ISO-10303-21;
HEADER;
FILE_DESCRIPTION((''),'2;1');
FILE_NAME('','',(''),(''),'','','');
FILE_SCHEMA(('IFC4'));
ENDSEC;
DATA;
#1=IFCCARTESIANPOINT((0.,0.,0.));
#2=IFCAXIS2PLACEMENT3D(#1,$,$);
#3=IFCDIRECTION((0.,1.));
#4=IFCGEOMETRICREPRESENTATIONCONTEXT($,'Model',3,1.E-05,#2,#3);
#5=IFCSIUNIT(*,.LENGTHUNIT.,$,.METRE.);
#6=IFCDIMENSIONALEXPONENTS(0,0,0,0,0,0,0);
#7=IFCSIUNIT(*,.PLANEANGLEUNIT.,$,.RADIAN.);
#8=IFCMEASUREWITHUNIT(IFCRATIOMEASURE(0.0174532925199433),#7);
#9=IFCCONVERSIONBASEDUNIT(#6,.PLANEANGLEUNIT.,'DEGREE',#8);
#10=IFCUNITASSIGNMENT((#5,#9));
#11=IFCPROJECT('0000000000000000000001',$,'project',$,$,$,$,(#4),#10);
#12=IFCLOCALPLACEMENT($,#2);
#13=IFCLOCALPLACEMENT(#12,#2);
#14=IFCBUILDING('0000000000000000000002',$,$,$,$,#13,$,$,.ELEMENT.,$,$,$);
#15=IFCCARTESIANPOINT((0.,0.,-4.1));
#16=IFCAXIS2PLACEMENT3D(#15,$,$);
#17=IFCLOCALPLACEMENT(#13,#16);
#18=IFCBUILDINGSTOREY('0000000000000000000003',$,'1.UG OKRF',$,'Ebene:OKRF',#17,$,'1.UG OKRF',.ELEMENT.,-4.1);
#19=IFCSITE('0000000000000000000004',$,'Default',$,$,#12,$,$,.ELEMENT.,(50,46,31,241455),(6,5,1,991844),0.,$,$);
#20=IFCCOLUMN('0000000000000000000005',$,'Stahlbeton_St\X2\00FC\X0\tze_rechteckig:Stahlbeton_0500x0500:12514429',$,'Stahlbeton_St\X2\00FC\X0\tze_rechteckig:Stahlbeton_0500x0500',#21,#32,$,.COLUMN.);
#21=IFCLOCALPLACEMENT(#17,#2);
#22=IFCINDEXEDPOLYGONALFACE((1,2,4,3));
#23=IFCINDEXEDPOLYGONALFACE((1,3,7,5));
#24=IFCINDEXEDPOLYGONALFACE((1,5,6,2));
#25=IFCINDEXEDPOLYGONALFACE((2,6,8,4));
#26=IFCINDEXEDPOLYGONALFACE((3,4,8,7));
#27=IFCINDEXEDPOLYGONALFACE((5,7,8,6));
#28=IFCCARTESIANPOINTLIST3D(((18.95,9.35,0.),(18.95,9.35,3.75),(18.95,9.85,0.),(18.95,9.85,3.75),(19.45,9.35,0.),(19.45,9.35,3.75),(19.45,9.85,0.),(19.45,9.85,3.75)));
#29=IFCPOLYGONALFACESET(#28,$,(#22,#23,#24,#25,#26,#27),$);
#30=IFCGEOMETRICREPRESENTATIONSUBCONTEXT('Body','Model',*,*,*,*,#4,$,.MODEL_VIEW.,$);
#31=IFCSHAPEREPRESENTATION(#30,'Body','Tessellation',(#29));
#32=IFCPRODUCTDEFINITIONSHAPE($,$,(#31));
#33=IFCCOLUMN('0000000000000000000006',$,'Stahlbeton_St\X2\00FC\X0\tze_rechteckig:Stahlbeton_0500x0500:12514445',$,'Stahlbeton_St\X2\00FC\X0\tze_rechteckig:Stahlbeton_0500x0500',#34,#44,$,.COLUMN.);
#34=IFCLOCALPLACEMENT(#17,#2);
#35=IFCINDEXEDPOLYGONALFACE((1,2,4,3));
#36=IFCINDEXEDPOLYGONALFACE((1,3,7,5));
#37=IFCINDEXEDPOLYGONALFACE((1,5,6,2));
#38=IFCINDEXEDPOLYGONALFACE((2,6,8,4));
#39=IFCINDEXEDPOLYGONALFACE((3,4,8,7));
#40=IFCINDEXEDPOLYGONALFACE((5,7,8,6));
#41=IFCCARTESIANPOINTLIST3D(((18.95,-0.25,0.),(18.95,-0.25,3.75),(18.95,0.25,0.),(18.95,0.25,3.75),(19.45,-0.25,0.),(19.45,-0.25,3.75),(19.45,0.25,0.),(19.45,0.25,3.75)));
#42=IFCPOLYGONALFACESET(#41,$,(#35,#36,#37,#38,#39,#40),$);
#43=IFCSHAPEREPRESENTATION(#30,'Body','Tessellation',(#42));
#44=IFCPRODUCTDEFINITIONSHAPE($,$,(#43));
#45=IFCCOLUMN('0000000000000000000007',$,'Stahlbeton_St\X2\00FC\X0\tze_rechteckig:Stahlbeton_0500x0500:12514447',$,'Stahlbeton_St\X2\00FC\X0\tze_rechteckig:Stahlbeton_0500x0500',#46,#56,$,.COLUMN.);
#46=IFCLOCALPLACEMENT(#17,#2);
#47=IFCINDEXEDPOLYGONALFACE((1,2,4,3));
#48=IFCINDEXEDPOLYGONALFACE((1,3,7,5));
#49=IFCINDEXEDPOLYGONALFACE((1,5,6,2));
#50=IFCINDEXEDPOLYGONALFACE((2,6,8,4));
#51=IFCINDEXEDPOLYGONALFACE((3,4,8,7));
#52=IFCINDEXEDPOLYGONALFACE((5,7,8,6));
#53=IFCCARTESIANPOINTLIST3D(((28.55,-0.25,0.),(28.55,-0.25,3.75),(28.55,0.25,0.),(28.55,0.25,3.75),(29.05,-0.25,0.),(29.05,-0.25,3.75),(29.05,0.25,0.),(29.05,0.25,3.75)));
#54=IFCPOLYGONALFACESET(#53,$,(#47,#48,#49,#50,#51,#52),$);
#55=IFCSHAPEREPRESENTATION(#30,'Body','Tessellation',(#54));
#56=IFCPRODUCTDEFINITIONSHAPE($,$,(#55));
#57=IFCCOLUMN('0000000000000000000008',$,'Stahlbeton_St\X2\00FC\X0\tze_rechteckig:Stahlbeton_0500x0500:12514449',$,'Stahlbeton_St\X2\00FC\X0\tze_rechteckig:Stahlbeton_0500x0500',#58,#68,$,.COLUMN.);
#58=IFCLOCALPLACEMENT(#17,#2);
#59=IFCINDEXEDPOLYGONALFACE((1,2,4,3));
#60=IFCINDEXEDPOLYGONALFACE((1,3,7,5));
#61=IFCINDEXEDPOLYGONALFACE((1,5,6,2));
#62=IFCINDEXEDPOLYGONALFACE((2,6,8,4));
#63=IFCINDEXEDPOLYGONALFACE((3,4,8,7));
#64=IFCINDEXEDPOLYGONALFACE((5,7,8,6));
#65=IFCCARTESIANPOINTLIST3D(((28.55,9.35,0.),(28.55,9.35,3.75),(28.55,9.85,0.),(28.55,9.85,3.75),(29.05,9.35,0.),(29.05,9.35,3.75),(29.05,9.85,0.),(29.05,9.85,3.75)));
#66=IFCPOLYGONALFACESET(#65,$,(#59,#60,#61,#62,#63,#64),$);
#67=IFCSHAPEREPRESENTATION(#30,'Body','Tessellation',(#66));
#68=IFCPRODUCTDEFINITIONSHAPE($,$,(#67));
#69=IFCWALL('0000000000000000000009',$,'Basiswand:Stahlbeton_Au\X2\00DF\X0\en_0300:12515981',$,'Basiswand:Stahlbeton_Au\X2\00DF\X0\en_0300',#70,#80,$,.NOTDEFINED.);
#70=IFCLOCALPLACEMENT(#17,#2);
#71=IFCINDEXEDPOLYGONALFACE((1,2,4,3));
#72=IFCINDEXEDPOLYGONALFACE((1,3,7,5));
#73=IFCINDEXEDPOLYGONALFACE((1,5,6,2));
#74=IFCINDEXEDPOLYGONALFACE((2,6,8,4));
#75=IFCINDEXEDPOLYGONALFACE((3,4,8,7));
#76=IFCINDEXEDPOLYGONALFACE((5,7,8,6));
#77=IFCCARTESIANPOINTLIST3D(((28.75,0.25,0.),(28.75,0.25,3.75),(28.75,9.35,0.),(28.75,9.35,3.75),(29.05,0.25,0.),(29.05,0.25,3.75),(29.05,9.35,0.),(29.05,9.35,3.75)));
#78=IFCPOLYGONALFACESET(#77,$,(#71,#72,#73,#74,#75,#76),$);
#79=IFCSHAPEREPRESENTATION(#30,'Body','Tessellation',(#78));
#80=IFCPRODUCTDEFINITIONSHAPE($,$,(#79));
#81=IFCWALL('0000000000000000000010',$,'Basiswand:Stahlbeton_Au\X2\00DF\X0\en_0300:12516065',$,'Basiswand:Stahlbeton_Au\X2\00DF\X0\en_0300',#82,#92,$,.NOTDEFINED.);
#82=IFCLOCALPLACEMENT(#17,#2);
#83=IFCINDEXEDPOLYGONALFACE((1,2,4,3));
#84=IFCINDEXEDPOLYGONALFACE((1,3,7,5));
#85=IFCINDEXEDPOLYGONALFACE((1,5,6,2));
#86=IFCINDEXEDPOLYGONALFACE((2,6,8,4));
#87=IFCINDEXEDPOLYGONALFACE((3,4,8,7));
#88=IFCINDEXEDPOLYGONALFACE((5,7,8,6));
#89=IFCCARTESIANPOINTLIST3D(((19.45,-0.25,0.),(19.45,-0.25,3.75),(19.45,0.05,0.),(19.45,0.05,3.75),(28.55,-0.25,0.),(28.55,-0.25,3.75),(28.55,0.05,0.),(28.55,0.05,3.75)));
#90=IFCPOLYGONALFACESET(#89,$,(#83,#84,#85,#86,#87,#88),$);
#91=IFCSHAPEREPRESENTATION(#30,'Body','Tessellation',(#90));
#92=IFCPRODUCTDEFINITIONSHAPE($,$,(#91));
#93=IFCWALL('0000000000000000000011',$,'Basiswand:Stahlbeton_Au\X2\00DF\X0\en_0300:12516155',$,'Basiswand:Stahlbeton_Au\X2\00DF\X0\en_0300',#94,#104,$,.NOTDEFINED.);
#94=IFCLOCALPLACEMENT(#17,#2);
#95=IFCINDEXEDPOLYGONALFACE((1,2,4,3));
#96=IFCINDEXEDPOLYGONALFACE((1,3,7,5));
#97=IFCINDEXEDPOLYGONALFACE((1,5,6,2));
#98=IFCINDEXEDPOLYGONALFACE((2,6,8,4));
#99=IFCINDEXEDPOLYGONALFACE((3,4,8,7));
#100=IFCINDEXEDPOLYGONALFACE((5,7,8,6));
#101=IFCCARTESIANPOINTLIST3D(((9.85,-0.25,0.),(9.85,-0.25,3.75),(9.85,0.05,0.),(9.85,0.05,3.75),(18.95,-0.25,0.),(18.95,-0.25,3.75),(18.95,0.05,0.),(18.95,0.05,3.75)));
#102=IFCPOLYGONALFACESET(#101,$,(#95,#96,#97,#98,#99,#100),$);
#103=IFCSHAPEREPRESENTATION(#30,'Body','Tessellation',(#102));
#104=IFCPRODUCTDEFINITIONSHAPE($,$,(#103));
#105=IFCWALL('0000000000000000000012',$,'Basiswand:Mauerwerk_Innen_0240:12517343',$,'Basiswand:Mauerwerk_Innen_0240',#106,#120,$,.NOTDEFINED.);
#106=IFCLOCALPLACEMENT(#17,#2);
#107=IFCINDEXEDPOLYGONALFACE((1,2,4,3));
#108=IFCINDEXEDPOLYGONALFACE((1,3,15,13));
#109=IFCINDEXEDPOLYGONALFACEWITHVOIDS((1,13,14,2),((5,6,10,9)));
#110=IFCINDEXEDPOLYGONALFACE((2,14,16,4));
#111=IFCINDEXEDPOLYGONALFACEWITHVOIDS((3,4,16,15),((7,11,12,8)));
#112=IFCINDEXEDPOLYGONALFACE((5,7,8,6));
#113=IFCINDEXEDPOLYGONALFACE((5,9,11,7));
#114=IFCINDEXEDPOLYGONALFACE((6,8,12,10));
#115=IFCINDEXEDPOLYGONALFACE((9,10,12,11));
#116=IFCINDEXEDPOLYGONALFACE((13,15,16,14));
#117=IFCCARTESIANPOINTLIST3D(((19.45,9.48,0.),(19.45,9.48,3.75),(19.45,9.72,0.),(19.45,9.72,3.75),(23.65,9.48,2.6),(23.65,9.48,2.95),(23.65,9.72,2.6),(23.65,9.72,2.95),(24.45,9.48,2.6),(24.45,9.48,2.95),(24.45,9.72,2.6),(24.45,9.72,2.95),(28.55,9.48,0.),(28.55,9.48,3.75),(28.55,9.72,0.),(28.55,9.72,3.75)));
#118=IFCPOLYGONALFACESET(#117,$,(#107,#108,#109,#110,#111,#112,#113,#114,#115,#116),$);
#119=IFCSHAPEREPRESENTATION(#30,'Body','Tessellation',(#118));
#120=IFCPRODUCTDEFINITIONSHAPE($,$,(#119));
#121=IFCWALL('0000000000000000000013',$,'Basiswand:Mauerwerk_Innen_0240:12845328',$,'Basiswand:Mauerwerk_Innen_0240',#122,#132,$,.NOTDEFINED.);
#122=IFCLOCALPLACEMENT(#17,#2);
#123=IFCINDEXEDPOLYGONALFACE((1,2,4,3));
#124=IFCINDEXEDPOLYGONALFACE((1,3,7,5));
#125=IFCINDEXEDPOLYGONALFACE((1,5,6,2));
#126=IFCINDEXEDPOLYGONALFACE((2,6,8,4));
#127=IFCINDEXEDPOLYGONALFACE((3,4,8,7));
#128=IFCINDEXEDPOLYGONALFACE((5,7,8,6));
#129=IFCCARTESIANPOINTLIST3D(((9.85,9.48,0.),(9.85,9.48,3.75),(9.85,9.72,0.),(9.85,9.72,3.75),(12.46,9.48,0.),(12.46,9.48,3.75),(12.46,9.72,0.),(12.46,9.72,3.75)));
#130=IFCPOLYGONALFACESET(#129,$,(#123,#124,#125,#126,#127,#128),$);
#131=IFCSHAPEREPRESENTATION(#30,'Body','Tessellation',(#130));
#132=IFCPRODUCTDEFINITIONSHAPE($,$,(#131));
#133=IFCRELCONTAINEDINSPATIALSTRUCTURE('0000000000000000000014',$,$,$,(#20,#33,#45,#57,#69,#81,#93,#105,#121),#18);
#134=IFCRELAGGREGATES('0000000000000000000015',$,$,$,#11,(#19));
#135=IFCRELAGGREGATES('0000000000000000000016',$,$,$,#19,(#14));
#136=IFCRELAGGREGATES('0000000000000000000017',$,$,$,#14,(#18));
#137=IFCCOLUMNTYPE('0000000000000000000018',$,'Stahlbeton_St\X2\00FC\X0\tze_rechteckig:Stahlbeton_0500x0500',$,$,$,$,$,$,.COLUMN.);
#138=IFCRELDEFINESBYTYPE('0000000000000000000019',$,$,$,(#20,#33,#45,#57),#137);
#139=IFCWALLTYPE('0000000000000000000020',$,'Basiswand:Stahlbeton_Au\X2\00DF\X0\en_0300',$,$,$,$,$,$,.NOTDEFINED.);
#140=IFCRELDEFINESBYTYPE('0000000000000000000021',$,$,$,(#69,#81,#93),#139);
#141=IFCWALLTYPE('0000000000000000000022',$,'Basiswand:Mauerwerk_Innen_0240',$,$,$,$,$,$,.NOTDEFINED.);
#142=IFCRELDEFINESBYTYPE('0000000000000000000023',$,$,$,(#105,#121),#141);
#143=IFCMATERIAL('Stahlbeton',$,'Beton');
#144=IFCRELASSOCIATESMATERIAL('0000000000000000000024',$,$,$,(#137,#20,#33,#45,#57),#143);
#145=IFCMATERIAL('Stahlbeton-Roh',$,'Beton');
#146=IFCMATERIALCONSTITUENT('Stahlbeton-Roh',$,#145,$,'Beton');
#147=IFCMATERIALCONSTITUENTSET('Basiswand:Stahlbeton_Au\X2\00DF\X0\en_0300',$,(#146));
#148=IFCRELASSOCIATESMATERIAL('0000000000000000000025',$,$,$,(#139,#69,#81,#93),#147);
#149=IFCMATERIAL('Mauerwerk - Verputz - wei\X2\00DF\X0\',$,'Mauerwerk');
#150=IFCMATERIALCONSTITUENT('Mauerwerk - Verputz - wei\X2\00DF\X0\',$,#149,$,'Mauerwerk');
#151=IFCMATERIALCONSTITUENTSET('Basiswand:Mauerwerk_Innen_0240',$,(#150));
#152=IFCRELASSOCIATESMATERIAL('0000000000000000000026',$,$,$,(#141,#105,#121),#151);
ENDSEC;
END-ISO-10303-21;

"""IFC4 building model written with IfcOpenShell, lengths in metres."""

from ifc_helpers import new_model, entity, si_unit, converted_unit, direction, frame, origin, place, context, subcontext, project, spatial, polyline, indexed_curve, outline, extrude, source, transform, mapped, material, constituent, constituent_set, type_object, type_shapes, element, save


model = new_model("IFC4")

# Units and contexts
model_context = context("Model", 3, precision=1e-05, world=origin(), true_north=direction((0.0, 1.0)))
body_context = subcontext(model_context, "Body", "Model", "MODEL_VIEW")
ifc_project = project(units=[si_unit("LENGTHUNIT", "METRE"), converted_unit("PLANEANGLEUNIT", "DEGREE", entity("IfcRatioMeasure", 0.0174532925199433), si_unit("PLANEANGLEUNIT", "RADIAN"), dimensions=[0, 0, 0, 0, 0, 0, 0])], contexts=[model_context])

# Site, building, storey
site_placement = place(None, origin())
site = spatial("IfcSite", under=ifc_project, at=site_placement, Name="Default", CompositionType="ELEMENT", RefLatitude=(50, 46, 31, 241455), RefLongitude=(6, 5, 1, 991844), RefElevation=0.0)
building_placement = place(site_placement, origin())
building = spatial("IfcBuilding", under=site, at=building_placement, CompositionType="ELEMENT")
storey_placement = place(building_placement, frame((0.0, 0.0, -4.1)))
storey = spatial("IfcBuildingStorey", under=building, at=storey_placement, Name="1.UG OKRF", ObjectType="Ebene:OKRF", LongName="1.UG OKRF", CompositionType="ELEMENT", Elevation=-4.1)

# Columns
ifc_material_1 = material(Name="Stahlbeton", Category="Beton")
column_type = type_object("IfcColumnType", Name="Stahlbeton_Stütze_rechteckig:Stahlbeton_0500x0500", PredefinedType="COLUMN", material=ifc_material_1)
shared_shape = source(origin(), body_context, "Body", "SweptSolid", [
    extrude(outline(indexed_curve([(-0.25, -0.25), (0.25, -0.25), (0.25, 0.25), (-0.25, 0.25), (-0.25, -0.25)], self_intersect=False)), frame((0.0, 0.0, -4.1), z_axis=(0.0, 0.0, 1.0), x_axis=(0.0, -1.0, 0.0)), (0.0, 0.0, 1.0), 3.75),
])
type_shapes(column_type, [shared_shape])
for number, where, name in (
    (1, (19.2, 9.6, 4.1), "Stahlbeton_Stütze_rechteckig:Stahlbeton_0500x0500:12514429"),
    (2, (19.2, 0.0, 4.1), "Stahlbeton_Stütze_rechteckig:Stahlbeton_0500x0500:12514445"),
    (3, (28.8, 0.0, 4.1), "Stahlbeton_Stütze_rechteckig:Stahlbeton_0500x0500:12514447"),
    (4, (28.8, 9.6, 4.1), "Stahlbeton_Stütze_rechteckig:Stahlbeton_0500x0500:12514449"),
):
    element("IfcColumn", number, at=place(storey_placement, frame(where)), inside=storey, type_object=column_type, material=ifc_material_1, Name=name, ObjectType="Stahlbeton_Stütze_rechteckig:Stahlbeton_0500x0500", PredefinedType="COLUMN", context=body_context, shape_type="MappedRepresentation", body=[
        mapped(shared_shape, transform((0.0, 0.0, 0.0), scale=1.0)),
    ])

# Walls
ifc_material_2 = material(Name="Stahlbeton-Roh", Category="Beton")
ifc_constituent_1 = constituent(ifc_material_2, Name="Stahlbeton-Roh", Category="Beton")
ifc_constituent_set_1 = constituent_set(constituents=[ifc_constituent_1], Name="Basiswand:Stahlbeton_Außen_0300")
wall_type_1 = type_object("IfcWallType", Name="Basiswand:Stahlbeton_Außen_0300", PredefinedType="NOTDEFINED", material=ifc_constituent_set_1)
wall_1_placement = place(storey_placement, frame((28.9, 9.35, 0.0), z_axis=(0.0, 0.0, 1.0), x_axis=(0.0, -1.0, 0.0)))
element("IfcWall", 5, at=wall_1_placement, inside=storey, type_object=wall_type_1, material=ifc_constituent_set_1, Name="Basiswand:Stahlbeton_Außen_0300:12515981", ObjectType="Basiswand:Stahlbeton_Außen_0300", PredefinedType="NOTDEFINED", context=body_context, shape_type="SweptSolid", body=[
    extrude(outline(polyline([(-4.55, -0.15), (4.55, -0.15), (4.55, 0.15), (-4.55, 0.15), (-4.55, -0.15)])), frame((4.55, 0.0, 0.0), z_axis=(0.0, 0.0, -1.0), x_axis=(-1.0, 0.0, 0.0)), (0.0, 0.0, -1.0), 3.75),
])
wall_2_placement = place(storey_placement, frame((28.55, -0.1, 0.0), z_axis=(0.0, 0.0, 1.0), x_axis=(-1.0, 0.0, 0.0)))
element("IfcWall", 6, at=wall_2_placement, inside=storey, type_object=wall_type_1, material=ifc_constituent_set_1, Name="Basiswand:Stahlbeton_Außen_0300:12516065", ObjectType="Basiswand:Stahlbeton_Außen_0300", PredefinedType="NOTDEFINED", context=body_context, shape_type="SweptSolid", body=[
    extrude(outline(polyline([(-0.15, -4.55), (0.15, -4.55), (0.15, 4.55), (-0.15, 4.55), (-0.15, -4.55)])), frame((4.55, 0.0, 0.0), z_axis=(0.0, 0.0, -1.0), x_axis=(0.0, 1.0, 0.0)), (0.0, 0.0, -1.0), 3.75),
])
wall_3_placement = place(storey_placement, frame((18.95, -0.1, 0.0), z_axis=(0.0, 0.0, 1.0), x_axis=(-1.0, 0.0, 0.0)))
element("IfcWall", 7, at=wall_3_placement, inside=storey, type_object=wall_type_1, material=ifc_constituent_set_1, Name="Basiswand:Stahlbeton_Außen_0300:12516155", ObjectType="Basiswand:Stahlbeton_Außen_0300", PredefinedType="NOTDEFINED", context=body_context, shape_type="SweptSolid", body=[
    extrude(outline(polyline([(-4.55, -0.15), (4.55, -0.15), (4.55, 0.15), (-4.55, 0.15), (-4.55, -0.15)])), frame((4.55, 0.0, 0.0), z_axis=(0.0, 0.0, -1.0), x_axis=(1.0, 0.0, 0.0)), (0.0, 0.0, -1.0), 3.75),
])

# Wall, opening
ifc_material_3 = material(Name="Mauerwerk - Verputz - weiß", Category="Mauerwerk")
ifc_constituent_2 = constituent(ifc_material_3, Name="Mauerwerk - Verputz - weiß", Category="Mauerwerk")
ifc_constituent_set_2 = constituent_set(constituents=[ifc_constituent_2], Name="Basiswand:Mauerwerk_Innen_0240")
wall_type_2 = type_object("IfcWallType", Name="Basiswand:Mauerwerk_Innen_0240", PredefinedType="NOTDEFINED", material=ifc_constituent_set_2)
wall_4_placement = place(storey_placement, frame((19.45, 9.6, 0.0)))
wall_4 = element("IfcWall", 8, at=wall_4_placement, inside=storey, type_object=wall_type_2, material=ifc_constituent_set_2, Name="Basiswand:Mauerwerk_Innen_0240:12517343", ObjectType="Basiswand:Mauerwerk_Innen_0240", PredefinedType="NOTDEFINED", context=body_context, shape_type="SweptSolid", body=[
    extrude(outline(indexed_curve([(-1.875, -4.55), (1.875, -4.55), (1.875, 4.55), (-1.875, 4.55), (-1.875, -4.55)], self_intersect=False), holes=[indexed_curve([(1.075, -0.35), (0.725, -0.35), (0.725, 0.45), (1.075, 0.45), (1.075, -0.35)], self_intersect=False)]), frame((4.55, -0.12, 1.875), z_axis=(0.0, 1.0, 0.0), x_axis=(0.0, 0.0, 1.0)), (0.0, 0.0, 1.0), 0.24),
])
opening_1_placement = place(wall_4_placement, origin())
element("IfcOpeningElement", 9, at=opening_1_placement, cuts=wall_4, ObjectType="Opening", PredefinedType="OPENING", context=body_context, shape_type="SweptSolid", body=[
    extrude(outline(indexed_curve([(-0.175, -0.4), (0.175, -0.4), (0.175, 0.4), (-0.175, 0.4), (-0.175, -0.4)], self_intersect=False)), frame((4.6, -0.12, 2.775), z_axis=(0.0, 1.0, 0.0), x_axis=(0.0, 0.0, -1.0)), (0.0, 0.0, 1.0), 0.24),
])

# Wall
wall_5_placement = place(storey_placement, frame((12.46, 9.6, 0.0), z_axis=(0.0, 0.0, 1.0), x_axis=(-1.0, 0.0, 0.0)))
element("IfcWall", 10, at=wall_5_placement, inside=storey, type_object=wall_type_2, material=ifc_constituent_set_2, Name="Basiswand:Mauerwerk_Innen_0240:12845328", ObjectType="Basiswand:Mauerwerk_Innen_0240", PredefinedType="NOTDEFINED", context=body_context, shape_type="SweptSolid", body=[
    extrude(outline(indexed_curve([(-0.12, -1.305), (0.12, -1.305), (0.12, 1.305), (-0.12, 1.305), (-0.12, -1.305)], self_intersect=False)), frame((1.305, 0.0, 0.0), z_axis=(0.0, 0.0, 1.0), x_axis=(0.0, 1.0, 0.0)), (0.0, 0.0, 1.0), 3.75),
])

save(model, "model.ifc")
